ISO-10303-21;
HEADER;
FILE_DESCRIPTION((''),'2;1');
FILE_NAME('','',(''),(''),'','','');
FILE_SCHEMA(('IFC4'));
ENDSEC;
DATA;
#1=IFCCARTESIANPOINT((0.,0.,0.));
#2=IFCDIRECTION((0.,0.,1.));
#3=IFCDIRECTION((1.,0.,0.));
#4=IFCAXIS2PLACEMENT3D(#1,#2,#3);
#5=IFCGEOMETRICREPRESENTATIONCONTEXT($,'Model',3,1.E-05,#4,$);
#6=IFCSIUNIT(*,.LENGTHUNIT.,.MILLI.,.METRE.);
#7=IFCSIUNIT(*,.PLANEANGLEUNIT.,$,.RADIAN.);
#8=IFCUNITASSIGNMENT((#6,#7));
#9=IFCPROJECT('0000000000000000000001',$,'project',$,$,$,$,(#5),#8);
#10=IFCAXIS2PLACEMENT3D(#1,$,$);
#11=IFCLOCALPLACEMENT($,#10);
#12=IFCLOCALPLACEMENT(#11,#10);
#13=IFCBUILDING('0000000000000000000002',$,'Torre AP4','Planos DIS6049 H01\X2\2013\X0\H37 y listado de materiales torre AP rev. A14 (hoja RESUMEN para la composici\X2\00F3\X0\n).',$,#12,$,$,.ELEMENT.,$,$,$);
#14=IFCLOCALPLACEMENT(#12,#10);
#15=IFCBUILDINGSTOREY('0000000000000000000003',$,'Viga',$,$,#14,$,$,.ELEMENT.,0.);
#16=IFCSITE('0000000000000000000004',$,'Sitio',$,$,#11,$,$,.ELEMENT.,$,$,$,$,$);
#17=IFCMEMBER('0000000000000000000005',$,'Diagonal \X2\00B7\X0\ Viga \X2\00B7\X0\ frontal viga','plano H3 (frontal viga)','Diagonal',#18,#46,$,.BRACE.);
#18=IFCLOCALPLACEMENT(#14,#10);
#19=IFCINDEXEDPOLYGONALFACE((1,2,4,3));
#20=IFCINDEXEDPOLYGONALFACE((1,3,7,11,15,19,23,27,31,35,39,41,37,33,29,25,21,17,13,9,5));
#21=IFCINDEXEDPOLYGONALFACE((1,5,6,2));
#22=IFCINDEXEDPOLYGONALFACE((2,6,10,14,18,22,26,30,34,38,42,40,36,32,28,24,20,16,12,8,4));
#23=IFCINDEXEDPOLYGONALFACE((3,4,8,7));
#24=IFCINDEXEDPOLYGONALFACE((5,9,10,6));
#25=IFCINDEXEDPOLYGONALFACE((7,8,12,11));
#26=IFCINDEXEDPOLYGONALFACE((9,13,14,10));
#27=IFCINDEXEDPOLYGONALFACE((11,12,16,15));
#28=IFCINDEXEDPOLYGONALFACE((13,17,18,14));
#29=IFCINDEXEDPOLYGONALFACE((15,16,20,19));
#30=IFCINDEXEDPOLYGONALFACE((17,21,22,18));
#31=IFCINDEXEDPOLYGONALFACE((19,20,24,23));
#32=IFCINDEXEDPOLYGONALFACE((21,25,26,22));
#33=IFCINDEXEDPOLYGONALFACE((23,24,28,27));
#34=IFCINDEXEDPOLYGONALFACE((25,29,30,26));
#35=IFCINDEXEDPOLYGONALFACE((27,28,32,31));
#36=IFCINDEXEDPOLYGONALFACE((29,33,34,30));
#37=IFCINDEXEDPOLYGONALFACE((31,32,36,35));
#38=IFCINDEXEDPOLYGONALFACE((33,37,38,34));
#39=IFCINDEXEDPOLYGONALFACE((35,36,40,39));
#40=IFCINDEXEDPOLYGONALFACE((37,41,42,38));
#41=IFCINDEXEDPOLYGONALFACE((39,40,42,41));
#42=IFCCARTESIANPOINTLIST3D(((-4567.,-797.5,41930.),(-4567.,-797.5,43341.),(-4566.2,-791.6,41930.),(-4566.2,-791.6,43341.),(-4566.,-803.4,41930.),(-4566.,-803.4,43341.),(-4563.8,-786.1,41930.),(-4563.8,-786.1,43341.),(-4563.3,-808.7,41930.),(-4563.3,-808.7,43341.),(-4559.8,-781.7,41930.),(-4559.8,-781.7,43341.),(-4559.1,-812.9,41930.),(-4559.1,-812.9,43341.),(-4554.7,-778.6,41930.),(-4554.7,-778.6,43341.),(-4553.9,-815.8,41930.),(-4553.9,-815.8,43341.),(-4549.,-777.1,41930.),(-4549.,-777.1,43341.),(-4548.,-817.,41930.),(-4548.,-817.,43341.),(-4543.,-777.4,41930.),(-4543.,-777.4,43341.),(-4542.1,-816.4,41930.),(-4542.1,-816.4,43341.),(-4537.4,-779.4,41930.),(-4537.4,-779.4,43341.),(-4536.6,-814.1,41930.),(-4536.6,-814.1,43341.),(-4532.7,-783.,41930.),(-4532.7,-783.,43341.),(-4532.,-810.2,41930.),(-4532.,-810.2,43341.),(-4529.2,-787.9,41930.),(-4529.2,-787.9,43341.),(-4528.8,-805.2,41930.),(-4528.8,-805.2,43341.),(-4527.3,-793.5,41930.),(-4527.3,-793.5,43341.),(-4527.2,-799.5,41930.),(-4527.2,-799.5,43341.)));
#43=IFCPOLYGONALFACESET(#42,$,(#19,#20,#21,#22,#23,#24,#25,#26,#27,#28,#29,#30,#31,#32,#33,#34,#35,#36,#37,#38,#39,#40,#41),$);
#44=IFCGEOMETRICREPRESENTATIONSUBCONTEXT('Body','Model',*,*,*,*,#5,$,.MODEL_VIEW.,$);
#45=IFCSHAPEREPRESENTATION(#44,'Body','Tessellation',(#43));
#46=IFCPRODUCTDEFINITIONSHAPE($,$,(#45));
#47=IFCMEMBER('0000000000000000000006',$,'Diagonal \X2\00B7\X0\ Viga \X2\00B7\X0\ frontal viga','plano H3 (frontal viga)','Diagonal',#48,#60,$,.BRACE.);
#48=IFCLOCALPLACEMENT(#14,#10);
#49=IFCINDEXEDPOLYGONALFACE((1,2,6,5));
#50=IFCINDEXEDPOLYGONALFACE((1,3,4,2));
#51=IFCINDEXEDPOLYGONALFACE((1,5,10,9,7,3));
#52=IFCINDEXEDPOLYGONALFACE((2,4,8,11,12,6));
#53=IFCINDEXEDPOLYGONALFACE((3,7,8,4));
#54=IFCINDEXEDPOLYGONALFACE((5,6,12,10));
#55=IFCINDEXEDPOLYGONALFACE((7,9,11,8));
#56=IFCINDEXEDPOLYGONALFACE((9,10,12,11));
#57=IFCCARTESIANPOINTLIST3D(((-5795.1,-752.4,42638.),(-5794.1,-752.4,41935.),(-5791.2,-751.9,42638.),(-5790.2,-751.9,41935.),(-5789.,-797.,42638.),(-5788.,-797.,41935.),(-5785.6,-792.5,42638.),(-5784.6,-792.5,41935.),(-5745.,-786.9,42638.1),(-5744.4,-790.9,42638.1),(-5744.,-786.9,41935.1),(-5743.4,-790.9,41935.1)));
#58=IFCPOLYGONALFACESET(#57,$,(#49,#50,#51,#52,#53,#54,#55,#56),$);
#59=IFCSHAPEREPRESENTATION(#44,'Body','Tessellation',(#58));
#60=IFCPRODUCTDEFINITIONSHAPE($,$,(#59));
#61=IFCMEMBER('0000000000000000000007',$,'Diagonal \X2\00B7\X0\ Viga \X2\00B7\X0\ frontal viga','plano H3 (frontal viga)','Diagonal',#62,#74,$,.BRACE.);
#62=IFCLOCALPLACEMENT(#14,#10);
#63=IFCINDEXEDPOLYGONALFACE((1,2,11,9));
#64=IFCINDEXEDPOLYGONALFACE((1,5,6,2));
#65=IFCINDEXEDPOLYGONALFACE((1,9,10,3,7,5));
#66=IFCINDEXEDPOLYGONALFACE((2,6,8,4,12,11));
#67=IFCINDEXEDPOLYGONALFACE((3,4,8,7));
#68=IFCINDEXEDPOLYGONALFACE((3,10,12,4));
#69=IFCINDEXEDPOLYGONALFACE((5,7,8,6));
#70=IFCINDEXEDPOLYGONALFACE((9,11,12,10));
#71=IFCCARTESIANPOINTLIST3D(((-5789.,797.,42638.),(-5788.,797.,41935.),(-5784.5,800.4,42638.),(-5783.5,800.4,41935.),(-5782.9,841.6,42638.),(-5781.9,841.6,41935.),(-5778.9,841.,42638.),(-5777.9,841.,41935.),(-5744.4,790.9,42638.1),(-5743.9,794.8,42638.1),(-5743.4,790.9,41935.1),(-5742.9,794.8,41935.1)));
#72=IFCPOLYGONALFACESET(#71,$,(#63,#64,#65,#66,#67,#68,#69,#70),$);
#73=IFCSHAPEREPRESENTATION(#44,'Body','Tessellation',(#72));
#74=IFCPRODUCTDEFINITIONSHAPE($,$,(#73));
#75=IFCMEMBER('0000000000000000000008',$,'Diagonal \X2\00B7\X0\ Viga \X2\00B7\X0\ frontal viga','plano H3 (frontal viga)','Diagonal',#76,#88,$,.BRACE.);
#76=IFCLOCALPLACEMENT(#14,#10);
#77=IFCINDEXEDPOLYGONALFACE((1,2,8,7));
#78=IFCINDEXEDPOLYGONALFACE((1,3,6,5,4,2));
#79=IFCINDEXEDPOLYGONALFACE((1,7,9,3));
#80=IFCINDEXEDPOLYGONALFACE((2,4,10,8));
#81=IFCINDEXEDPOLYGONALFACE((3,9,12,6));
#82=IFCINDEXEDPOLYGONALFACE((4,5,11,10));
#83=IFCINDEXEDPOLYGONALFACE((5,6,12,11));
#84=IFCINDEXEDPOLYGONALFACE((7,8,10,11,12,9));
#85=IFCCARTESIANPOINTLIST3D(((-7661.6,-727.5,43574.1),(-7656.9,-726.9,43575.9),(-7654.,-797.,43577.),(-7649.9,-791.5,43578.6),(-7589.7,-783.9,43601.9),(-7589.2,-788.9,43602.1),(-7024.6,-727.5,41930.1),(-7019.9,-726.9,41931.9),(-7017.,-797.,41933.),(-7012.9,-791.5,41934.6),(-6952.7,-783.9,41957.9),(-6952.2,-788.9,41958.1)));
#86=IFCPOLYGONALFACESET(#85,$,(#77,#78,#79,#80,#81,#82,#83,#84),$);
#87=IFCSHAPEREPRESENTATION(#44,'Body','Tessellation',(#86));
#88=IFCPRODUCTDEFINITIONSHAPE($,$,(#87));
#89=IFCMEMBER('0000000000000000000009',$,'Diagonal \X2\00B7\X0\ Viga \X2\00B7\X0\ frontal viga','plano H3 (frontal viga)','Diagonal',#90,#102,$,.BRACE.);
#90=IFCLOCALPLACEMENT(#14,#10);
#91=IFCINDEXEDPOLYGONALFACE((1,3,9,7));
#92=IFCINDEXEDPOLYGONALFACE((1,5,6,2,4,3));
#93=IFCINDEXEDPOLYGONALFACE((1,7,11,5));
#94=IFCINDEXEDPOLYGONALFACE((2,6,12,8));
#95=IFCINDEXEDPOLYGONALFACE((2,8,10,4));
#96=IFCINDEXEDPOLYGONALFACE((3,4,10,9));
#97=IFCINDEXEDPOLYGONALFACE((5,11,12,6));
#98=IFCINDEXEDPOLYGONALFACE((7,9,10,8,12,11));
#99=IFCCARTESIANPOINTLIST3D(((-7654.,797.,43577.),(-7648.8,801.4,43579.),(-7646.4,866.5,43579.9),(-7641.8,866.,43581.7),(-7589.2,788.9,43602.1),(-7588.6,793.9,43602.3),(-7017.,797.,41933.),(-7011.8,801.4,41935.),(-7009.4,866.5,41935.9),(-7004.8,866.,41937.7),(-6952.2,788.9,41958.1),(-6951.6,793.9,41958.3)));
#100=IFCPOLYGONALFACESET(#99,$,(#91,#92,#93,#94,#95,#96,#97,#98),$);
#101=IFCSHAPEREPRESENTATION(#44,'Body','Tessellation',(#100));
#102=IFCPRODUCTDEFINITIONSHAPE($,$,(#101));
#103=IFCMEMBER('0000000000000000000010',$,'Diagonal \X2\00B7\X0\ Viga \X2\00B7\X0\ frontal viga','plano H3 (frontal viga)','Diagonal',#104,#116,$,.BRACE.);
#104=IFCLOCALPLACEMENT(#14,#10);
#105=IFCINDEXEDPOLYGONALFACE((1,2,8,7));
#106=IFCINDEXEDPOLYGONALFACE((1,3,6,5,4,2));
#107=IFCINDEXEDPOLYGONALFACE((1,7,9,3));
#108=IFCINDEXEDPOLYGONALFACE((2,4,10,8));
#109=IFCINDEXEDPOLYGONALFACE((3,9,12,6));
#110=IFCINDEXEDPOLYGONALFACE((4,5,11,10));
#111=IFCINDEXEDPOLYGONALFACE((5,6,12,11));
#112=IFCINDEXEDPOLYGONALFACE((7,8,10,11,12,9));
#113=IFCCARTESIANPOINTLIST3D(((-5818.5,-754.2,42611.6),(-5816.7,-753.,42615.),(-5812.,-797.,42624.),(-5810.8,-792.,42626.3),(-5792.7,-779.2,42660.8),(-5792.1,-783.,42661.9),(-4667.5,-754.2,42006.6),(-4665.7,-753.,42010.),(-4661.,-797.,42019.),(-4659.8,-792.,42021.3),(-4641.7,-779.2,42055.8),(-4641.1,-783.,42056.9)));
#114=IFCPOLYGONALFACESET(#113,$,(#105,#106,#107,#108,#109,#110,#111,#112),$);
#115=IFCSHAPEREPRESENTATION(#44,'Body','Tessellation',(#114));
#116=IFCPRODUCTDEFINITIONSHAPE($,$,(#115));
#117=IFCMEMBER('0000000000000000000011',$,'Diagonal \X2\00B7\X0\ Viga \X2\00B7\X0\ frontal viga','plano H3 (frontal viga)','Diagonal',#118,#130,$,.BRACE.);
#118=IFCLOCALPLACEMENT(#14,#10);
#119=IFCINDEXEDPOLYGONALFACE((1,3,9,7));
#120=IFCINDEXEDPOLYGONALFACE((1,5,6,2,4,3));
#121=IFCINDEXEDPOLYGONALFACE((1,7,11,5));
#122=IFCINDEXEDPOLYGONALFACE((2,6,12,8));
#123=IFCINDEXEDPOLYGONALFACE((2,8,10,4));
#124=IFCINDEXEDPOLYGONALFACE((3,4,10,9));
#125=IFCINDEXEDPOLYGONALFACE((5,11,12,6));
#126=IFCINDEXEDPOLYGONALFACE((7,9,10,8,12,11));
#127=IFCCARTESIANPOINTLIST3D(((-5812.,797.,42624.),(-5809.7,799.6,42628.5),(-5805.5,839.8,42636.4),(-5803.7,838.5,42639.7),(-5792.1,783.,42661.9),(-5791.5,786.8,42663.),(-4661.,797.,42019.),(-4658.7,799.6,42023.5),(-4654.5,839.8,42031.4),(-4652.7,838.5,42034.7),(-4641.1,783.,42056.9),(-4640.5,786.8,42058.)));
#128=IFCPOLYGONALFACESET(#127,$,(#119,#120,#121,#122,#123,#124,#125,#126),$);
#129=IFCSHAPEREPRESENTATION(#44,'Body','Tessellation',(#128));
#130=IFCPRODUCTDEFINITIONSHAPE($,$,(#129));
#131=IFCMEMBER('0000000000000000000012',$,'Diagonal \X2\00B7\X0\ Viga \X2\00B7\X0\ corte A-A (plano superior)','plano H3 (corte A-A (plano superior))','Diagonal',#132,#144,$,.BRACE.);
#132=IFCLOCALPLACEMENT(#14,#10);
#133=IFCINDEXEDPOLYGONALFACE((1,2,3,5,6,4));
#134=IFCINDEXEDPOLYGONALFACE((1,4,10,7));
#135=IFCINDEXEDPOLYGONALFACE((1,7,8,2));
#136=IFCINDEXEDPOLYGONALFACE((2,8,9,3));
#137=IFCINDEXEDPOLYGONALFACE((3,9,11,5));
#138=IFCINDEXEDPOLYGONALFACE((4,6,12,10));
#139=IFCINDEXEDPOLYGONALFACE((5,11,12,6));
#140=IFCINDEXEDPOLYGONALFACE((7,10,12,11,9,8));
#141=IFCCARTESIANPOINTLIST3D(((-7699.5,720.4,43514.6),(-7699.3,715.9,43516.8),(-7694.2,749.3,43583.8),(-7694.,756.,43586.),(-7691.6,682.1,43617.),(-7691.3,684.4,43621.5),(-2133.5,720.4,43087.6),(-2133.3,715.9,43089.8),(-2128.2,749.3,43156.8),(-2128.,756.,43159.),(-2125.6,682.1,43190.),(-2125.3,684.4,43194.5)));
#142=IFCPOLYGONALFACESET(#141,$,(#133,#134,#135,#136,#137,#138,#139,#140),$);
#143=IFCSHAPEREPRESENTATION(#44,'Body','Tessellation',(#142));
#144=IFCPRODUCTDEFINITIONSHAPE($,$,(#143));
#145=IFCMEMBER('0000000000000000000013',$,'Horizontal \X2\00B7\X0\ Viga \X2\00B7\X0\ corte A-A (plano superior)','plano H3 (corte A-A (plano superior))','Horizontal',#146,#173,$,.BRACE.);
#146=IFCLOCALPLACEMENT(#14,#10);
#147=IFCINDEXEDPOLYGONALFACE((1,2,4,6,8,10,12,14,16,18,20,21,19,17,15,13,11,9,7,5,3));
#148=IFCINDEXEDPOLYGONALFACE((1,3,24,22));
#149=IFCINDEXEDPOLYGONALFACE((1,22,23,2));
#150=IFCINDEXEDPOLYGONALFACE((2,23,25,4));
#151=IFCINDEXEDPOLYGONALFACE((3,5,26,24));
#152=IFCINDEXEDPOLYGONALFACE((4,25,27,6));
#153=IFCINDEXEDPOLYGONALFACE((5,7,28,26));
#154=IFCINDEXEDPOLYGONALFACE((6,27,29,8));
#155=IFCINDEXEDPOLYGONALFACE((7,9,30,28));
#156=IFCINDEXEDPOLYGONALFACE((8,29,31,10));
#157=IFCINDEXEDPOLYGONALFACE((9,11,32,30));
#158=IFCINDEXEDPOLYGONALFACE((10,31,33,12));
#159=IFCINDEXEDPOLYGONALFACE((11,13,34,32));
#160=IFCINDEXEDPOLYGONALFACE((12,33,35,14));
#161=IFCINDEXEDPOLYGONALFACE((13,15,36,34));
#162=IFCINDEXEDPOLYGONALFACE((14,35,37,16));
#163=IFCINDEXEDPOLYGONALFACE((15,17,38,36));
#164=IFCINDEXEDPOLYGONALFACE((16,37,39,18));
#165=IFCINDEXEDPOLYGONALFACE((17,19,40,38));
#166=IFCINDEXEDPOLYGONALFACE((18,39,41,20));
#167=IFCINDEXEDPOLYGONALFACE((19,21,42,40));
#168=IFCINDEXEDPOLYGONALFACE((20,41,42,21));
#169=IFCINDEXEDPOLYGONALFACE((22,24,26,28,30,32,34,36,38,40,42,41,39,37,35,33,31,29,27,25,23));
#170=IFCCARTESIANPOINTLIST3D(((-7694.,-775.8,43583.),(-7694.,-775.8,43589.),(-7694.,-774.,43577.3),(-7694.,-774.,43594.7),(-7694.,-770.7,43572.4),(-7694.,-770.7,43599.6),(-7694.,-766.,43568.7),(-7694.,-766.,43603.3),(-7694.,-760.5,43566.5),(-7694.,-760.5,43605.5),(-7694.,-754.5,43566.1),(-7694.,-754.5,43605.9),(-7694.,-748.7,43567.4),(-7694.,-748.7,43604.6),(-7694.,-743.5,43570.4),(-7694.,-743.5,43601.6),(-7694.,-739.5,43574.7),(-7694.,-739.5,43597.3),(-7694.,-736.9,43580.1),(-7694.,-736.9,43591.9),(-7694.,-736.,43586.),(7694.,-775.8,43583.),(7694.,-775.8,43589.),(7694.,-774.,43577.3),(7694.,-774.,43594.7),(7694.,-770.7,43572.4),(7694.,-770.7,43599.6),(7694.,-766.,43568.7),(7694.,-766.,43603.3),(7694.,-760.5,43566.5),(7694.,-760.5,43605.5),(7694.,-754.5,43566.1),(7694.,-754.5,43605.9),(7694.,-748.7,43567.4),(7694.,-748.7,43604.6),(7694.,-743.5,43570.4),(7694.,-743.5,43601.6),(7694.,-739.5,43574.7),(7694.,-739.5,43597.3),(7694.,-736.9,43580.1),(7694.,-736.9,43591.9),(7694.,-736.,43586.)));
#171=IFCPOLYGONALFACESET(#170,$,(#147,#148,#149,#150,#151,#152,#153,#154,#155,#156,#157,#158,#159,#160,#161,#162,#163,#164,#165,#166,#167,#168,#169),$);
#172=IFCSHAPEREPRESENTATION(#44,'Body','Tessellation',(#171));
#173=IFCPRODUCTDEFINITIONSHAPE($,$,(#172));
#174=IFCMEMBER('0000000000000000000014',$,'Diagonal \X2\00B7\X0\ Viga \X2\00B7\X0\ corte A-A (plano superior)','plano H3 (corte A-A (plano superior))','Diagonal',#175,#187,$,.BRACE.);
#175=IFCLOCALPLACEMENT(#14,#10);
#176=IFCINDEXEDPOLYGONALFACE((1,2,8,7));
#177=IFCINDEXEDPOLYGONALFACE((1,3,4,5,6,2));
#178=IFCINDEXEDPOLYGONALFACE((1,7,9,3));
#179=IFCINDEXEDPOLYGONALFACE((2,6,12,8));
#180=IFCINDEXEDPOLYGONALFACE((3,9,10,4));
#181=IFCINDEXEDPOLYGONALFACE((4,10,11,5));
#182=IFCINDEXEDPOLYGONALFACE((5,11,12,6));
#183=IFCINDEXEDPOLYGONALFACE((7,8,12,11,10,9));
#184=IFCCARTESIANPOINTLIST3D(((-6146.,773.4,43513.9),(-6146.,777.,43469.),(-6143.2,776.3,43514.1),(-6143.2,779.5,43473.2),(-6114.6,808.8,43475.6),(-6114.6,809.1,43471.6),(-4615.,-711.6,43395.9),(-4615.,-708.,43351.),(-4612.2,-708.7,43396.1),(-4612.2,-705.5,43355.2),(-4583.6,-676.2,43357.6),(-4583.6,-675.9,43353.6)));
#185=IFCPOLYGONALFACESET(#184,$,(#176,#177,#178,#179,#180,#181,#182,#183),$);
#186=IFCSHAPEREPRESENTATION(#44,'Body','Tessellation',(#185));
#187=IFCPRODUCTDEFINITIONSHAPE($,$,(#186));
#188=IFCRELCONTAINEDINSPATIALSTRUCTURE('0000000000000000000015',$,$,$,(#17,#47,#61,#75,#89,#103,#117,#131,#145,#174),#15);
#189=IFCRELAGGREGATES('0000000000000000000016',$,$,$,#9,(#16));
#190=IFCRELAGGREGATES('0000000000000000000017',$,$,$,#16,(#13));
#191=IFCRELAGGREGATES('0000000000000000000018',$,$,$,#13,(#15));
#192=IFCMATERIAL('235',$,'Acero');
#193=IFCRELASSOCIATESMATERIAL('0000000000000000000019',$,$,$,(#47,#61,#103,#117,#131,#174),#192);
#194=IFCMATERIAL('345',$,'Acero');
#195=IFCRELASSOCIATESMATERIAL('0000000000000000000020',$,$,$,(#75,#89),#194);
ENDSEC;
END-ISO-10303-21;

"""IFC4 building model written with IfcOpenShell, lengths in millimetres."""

from ifc_helpers import new_model, si_unit, frame, frame_2d, origin, origin_with_axes, place, context, subcontext, project, spatial, circle, l_section, extrude, material, element, save


model = new_model("IFC4")

# Units and contexts
model_context = context("Model", 3, precision=1e-05, world=origin_with_axes())
body_context = subcontext(model_context, "Body", "Model", "MODEL_VIEW")
ifc_project = project(units=[si_unit("LENGTHUNIT", "METRE", prefix="MILLI"), si_unit("PLANEANGLEUNIT", "RADIAN")], contexts=[model_context])

# Site, building, storey
site_placement = place(None, origin())
site = spatial("IfcSite", under=ifc_project, at=site_placement, Name="Sitio", CompositionType="ELEMENT")
building_placement = place(site_placement, origin())
building = spatial("IfcBuilding", under=site, at=building_placement, Name="Torre AP4", Description="Planos DIS6049 H01–H37 y listado de materiales torre AP rev. A14 (hoja RESUMEN para la composición).", CompositionType="ELEMENT")
storey_placement = place(building_placement, origin())
storey = spatial("IfcBuildingStorey", under=building, at=storey_placement, Name="Viga", CompositionType="ELEMENT", Elevation=0.0)

# Members
ifc_material_1 = material(Name="345", Category="Acero")
member_1_placement = place(storey_placement, frame((-4547.0, -797.0, 41930.0), z_axis=(0.0, 0.0, 1.0), x_axis=(0.984984, 0.172648, 0.0)))
element("IfcMember", 1, at=member_1_placement, inside=storey, Name="Diagonal · Viga · frontal viga", Description="plano H3 (frontal viga)", ObjectType="Diagonal", PredefinedType="BRACE", context=body_context, shape_type="SweptSolid", body=[
    extrude(circle(Radius=20.0), None, (0.0, 0.0, 1.0), 1411.0),
])
ifc_material_2 = material(Name="235", Category="Acero")
for number, where, z_axis, x_axis, name in (
    (2, (-5788.0, -797.0, 41935.0), (-0.001422, 0.0, 0.999999), (0.990653, 0.1364, 0.001409), "Diagonal · Viga · frontal viga"),
    (3, (-5788.0, 797.0, 41935.0), (-0.001422, 0.0, 0.999999), (0.990653, -0.1364, 0.001409), "Diagonal · Viga · frontal viga"),
):
    element("IfcMember", number, at=place(storey_placement, frame(where, z_axis=z_axis, x_axis=x_axis)), inside=storey, material=ifc_material_2, Name=name, Description="plano H3 (frontal viga)", ObjectType="Diagonal", PredefinedType="BRACE", context=body_context, shape_type="SweptSolid", body=[
        extrude(l_section(Depth=45.0, Width=45.0, Thickness=4.0, at=frame_2d((22.5, 22.5))), None, (0.0, 0.0, 1.0), 703.0),
    ])
for number, where, z_axis, x_axis, name in (
    (4, (-7017.0, -797.0, 41933.0), (-0.361296, 0.0, 0.932451), (0.926185, 0.115738, 0.358868), "Diagonal · Viga · frontal viga"),
    (5, (-7017.0, 797.0, 41933.0), (-0.361296, 0.0, 0.932451), (0.926185, -0.115738, 0.358868), "Diagonal · Viga · frontal viga"),
):
    element("IfcMember", number, at=place(storey_placement, frame(where, z_axis=z_axis, x_axis=x_axis)), inside=storey, material=ifc_material_1, Name=name, Description="plano H3 (frontal viga)", ObjectType="Diagonal", PredefinedType="BRACE", context=body_context, shape_type="SweptSolid", body=[
        extrude(l_section(Depth=70.0, Width=70.0, Thickness=5.0, at=frame_2d((35.0, 35.0))), None, (0.0, 0.0, 1.0), 1763.1),
    ])
for number, where, z_axis, x_axis, name in (
    (6, (-4661.0, -797.0, 42019.0), (-0.885168, 0.0, 0.465271), (0.442212, 0.310911, 0.841299), "Diagonal · Viga · frontal viga"),
    (7, (-4661.0, 797.0, 42019.0), (-0.885168, 0.0, 0.465271), (0.442212, -0.310911, 0.841299), "Diagonal · Viga · frontal viga"),
):
    element("IfcMember", number, at=place(storey_placement, frame(where, z_axis=z_axis, x_axis=x_axis)), inside=storey, material=ifc_material_2, Name=name, Description="plano H3 (frontal viga)", ObjectType="Diagonal", PredefinedType="BRACE", context=body_context, shape_type="SweptSolid", body=[
        extrude(l_section(Depth=45.0, Width=45.0, Thickness=4.0, at=frame_2d((22.5, 22.5))), None, (0.0, 0.0, 1.0), 1300.3),
    ])
member_2_placement = place(storey_placement, frame((-7694.0, 756.0, 43586.0), z_axis=(0.99707, 0.0, -0.076491), x_axis=(0.034037, -0.895539, 0.443679)))
element("IfcMember", 8, at=member_2_placement, inside=storey, material=ifc_material_2, Name="Diagonal · Viga · corte A-A (plano superior)", Description="plano H3 (corte A-A (plano superior))", ObjectType="Diagonal", PredefinedType="BRACE", context=body_context, shape_type="SweptSolid", body=[
    extrude(l_section(Depth=80.0, Width=80.0, Thickness=5.0, at=frame_2d((40.0, 40.0))), None, (0.0, 0.0, 1.0), 5582.4),
])
member_3_placement = place(storey_placement, frame((-7694.0, -756.0, 43586.0), z_axis=(1.0, 0.0, 0.0), x_axis=(0.0, 1.0, 0.0)))
element("IfcMember", 9, at=member_3_placement, inside=storey, Name="Horizontal · Viga · corte A-A (plano superior)", Description="plano H3 (corte A-A (plano superior))", ObjectType="Horizontal", PredefinedType="BRACE", context=body_context, shape_type="SweptSolid", body=[
    extrude(circle(Radius=20.0), None, (0.0, 0.0, 1.0), 15388.0),
])
member_4_placement = place(storey_placement, frame((-6146.0, 777.0, 43469.0), z_axis=(0.716712, -0.695178, -0.05524), x_axis=(0.697369, 0.714402, 0.057503)))
element("IfcMember", 10, at=member_4_placement, inside=storey, material=ifc_material_2, Name="Diagonal · Viga · corte A-A (plano superior)", Description="plano H3 (corte A-A (plano superior))", ObjectType="Diagonal", PredefinedType="BRACE", context=body_context, shape_type="SweptSolid", body=[
    extrude(l_section(Depth=45.0, Width=45.0, Thickness=4.0, at=frame_2d((22.5, 22.5))), None, (0.0, 0.0, 1.0), 2136.1),
])

save(model, "model.ifc")
